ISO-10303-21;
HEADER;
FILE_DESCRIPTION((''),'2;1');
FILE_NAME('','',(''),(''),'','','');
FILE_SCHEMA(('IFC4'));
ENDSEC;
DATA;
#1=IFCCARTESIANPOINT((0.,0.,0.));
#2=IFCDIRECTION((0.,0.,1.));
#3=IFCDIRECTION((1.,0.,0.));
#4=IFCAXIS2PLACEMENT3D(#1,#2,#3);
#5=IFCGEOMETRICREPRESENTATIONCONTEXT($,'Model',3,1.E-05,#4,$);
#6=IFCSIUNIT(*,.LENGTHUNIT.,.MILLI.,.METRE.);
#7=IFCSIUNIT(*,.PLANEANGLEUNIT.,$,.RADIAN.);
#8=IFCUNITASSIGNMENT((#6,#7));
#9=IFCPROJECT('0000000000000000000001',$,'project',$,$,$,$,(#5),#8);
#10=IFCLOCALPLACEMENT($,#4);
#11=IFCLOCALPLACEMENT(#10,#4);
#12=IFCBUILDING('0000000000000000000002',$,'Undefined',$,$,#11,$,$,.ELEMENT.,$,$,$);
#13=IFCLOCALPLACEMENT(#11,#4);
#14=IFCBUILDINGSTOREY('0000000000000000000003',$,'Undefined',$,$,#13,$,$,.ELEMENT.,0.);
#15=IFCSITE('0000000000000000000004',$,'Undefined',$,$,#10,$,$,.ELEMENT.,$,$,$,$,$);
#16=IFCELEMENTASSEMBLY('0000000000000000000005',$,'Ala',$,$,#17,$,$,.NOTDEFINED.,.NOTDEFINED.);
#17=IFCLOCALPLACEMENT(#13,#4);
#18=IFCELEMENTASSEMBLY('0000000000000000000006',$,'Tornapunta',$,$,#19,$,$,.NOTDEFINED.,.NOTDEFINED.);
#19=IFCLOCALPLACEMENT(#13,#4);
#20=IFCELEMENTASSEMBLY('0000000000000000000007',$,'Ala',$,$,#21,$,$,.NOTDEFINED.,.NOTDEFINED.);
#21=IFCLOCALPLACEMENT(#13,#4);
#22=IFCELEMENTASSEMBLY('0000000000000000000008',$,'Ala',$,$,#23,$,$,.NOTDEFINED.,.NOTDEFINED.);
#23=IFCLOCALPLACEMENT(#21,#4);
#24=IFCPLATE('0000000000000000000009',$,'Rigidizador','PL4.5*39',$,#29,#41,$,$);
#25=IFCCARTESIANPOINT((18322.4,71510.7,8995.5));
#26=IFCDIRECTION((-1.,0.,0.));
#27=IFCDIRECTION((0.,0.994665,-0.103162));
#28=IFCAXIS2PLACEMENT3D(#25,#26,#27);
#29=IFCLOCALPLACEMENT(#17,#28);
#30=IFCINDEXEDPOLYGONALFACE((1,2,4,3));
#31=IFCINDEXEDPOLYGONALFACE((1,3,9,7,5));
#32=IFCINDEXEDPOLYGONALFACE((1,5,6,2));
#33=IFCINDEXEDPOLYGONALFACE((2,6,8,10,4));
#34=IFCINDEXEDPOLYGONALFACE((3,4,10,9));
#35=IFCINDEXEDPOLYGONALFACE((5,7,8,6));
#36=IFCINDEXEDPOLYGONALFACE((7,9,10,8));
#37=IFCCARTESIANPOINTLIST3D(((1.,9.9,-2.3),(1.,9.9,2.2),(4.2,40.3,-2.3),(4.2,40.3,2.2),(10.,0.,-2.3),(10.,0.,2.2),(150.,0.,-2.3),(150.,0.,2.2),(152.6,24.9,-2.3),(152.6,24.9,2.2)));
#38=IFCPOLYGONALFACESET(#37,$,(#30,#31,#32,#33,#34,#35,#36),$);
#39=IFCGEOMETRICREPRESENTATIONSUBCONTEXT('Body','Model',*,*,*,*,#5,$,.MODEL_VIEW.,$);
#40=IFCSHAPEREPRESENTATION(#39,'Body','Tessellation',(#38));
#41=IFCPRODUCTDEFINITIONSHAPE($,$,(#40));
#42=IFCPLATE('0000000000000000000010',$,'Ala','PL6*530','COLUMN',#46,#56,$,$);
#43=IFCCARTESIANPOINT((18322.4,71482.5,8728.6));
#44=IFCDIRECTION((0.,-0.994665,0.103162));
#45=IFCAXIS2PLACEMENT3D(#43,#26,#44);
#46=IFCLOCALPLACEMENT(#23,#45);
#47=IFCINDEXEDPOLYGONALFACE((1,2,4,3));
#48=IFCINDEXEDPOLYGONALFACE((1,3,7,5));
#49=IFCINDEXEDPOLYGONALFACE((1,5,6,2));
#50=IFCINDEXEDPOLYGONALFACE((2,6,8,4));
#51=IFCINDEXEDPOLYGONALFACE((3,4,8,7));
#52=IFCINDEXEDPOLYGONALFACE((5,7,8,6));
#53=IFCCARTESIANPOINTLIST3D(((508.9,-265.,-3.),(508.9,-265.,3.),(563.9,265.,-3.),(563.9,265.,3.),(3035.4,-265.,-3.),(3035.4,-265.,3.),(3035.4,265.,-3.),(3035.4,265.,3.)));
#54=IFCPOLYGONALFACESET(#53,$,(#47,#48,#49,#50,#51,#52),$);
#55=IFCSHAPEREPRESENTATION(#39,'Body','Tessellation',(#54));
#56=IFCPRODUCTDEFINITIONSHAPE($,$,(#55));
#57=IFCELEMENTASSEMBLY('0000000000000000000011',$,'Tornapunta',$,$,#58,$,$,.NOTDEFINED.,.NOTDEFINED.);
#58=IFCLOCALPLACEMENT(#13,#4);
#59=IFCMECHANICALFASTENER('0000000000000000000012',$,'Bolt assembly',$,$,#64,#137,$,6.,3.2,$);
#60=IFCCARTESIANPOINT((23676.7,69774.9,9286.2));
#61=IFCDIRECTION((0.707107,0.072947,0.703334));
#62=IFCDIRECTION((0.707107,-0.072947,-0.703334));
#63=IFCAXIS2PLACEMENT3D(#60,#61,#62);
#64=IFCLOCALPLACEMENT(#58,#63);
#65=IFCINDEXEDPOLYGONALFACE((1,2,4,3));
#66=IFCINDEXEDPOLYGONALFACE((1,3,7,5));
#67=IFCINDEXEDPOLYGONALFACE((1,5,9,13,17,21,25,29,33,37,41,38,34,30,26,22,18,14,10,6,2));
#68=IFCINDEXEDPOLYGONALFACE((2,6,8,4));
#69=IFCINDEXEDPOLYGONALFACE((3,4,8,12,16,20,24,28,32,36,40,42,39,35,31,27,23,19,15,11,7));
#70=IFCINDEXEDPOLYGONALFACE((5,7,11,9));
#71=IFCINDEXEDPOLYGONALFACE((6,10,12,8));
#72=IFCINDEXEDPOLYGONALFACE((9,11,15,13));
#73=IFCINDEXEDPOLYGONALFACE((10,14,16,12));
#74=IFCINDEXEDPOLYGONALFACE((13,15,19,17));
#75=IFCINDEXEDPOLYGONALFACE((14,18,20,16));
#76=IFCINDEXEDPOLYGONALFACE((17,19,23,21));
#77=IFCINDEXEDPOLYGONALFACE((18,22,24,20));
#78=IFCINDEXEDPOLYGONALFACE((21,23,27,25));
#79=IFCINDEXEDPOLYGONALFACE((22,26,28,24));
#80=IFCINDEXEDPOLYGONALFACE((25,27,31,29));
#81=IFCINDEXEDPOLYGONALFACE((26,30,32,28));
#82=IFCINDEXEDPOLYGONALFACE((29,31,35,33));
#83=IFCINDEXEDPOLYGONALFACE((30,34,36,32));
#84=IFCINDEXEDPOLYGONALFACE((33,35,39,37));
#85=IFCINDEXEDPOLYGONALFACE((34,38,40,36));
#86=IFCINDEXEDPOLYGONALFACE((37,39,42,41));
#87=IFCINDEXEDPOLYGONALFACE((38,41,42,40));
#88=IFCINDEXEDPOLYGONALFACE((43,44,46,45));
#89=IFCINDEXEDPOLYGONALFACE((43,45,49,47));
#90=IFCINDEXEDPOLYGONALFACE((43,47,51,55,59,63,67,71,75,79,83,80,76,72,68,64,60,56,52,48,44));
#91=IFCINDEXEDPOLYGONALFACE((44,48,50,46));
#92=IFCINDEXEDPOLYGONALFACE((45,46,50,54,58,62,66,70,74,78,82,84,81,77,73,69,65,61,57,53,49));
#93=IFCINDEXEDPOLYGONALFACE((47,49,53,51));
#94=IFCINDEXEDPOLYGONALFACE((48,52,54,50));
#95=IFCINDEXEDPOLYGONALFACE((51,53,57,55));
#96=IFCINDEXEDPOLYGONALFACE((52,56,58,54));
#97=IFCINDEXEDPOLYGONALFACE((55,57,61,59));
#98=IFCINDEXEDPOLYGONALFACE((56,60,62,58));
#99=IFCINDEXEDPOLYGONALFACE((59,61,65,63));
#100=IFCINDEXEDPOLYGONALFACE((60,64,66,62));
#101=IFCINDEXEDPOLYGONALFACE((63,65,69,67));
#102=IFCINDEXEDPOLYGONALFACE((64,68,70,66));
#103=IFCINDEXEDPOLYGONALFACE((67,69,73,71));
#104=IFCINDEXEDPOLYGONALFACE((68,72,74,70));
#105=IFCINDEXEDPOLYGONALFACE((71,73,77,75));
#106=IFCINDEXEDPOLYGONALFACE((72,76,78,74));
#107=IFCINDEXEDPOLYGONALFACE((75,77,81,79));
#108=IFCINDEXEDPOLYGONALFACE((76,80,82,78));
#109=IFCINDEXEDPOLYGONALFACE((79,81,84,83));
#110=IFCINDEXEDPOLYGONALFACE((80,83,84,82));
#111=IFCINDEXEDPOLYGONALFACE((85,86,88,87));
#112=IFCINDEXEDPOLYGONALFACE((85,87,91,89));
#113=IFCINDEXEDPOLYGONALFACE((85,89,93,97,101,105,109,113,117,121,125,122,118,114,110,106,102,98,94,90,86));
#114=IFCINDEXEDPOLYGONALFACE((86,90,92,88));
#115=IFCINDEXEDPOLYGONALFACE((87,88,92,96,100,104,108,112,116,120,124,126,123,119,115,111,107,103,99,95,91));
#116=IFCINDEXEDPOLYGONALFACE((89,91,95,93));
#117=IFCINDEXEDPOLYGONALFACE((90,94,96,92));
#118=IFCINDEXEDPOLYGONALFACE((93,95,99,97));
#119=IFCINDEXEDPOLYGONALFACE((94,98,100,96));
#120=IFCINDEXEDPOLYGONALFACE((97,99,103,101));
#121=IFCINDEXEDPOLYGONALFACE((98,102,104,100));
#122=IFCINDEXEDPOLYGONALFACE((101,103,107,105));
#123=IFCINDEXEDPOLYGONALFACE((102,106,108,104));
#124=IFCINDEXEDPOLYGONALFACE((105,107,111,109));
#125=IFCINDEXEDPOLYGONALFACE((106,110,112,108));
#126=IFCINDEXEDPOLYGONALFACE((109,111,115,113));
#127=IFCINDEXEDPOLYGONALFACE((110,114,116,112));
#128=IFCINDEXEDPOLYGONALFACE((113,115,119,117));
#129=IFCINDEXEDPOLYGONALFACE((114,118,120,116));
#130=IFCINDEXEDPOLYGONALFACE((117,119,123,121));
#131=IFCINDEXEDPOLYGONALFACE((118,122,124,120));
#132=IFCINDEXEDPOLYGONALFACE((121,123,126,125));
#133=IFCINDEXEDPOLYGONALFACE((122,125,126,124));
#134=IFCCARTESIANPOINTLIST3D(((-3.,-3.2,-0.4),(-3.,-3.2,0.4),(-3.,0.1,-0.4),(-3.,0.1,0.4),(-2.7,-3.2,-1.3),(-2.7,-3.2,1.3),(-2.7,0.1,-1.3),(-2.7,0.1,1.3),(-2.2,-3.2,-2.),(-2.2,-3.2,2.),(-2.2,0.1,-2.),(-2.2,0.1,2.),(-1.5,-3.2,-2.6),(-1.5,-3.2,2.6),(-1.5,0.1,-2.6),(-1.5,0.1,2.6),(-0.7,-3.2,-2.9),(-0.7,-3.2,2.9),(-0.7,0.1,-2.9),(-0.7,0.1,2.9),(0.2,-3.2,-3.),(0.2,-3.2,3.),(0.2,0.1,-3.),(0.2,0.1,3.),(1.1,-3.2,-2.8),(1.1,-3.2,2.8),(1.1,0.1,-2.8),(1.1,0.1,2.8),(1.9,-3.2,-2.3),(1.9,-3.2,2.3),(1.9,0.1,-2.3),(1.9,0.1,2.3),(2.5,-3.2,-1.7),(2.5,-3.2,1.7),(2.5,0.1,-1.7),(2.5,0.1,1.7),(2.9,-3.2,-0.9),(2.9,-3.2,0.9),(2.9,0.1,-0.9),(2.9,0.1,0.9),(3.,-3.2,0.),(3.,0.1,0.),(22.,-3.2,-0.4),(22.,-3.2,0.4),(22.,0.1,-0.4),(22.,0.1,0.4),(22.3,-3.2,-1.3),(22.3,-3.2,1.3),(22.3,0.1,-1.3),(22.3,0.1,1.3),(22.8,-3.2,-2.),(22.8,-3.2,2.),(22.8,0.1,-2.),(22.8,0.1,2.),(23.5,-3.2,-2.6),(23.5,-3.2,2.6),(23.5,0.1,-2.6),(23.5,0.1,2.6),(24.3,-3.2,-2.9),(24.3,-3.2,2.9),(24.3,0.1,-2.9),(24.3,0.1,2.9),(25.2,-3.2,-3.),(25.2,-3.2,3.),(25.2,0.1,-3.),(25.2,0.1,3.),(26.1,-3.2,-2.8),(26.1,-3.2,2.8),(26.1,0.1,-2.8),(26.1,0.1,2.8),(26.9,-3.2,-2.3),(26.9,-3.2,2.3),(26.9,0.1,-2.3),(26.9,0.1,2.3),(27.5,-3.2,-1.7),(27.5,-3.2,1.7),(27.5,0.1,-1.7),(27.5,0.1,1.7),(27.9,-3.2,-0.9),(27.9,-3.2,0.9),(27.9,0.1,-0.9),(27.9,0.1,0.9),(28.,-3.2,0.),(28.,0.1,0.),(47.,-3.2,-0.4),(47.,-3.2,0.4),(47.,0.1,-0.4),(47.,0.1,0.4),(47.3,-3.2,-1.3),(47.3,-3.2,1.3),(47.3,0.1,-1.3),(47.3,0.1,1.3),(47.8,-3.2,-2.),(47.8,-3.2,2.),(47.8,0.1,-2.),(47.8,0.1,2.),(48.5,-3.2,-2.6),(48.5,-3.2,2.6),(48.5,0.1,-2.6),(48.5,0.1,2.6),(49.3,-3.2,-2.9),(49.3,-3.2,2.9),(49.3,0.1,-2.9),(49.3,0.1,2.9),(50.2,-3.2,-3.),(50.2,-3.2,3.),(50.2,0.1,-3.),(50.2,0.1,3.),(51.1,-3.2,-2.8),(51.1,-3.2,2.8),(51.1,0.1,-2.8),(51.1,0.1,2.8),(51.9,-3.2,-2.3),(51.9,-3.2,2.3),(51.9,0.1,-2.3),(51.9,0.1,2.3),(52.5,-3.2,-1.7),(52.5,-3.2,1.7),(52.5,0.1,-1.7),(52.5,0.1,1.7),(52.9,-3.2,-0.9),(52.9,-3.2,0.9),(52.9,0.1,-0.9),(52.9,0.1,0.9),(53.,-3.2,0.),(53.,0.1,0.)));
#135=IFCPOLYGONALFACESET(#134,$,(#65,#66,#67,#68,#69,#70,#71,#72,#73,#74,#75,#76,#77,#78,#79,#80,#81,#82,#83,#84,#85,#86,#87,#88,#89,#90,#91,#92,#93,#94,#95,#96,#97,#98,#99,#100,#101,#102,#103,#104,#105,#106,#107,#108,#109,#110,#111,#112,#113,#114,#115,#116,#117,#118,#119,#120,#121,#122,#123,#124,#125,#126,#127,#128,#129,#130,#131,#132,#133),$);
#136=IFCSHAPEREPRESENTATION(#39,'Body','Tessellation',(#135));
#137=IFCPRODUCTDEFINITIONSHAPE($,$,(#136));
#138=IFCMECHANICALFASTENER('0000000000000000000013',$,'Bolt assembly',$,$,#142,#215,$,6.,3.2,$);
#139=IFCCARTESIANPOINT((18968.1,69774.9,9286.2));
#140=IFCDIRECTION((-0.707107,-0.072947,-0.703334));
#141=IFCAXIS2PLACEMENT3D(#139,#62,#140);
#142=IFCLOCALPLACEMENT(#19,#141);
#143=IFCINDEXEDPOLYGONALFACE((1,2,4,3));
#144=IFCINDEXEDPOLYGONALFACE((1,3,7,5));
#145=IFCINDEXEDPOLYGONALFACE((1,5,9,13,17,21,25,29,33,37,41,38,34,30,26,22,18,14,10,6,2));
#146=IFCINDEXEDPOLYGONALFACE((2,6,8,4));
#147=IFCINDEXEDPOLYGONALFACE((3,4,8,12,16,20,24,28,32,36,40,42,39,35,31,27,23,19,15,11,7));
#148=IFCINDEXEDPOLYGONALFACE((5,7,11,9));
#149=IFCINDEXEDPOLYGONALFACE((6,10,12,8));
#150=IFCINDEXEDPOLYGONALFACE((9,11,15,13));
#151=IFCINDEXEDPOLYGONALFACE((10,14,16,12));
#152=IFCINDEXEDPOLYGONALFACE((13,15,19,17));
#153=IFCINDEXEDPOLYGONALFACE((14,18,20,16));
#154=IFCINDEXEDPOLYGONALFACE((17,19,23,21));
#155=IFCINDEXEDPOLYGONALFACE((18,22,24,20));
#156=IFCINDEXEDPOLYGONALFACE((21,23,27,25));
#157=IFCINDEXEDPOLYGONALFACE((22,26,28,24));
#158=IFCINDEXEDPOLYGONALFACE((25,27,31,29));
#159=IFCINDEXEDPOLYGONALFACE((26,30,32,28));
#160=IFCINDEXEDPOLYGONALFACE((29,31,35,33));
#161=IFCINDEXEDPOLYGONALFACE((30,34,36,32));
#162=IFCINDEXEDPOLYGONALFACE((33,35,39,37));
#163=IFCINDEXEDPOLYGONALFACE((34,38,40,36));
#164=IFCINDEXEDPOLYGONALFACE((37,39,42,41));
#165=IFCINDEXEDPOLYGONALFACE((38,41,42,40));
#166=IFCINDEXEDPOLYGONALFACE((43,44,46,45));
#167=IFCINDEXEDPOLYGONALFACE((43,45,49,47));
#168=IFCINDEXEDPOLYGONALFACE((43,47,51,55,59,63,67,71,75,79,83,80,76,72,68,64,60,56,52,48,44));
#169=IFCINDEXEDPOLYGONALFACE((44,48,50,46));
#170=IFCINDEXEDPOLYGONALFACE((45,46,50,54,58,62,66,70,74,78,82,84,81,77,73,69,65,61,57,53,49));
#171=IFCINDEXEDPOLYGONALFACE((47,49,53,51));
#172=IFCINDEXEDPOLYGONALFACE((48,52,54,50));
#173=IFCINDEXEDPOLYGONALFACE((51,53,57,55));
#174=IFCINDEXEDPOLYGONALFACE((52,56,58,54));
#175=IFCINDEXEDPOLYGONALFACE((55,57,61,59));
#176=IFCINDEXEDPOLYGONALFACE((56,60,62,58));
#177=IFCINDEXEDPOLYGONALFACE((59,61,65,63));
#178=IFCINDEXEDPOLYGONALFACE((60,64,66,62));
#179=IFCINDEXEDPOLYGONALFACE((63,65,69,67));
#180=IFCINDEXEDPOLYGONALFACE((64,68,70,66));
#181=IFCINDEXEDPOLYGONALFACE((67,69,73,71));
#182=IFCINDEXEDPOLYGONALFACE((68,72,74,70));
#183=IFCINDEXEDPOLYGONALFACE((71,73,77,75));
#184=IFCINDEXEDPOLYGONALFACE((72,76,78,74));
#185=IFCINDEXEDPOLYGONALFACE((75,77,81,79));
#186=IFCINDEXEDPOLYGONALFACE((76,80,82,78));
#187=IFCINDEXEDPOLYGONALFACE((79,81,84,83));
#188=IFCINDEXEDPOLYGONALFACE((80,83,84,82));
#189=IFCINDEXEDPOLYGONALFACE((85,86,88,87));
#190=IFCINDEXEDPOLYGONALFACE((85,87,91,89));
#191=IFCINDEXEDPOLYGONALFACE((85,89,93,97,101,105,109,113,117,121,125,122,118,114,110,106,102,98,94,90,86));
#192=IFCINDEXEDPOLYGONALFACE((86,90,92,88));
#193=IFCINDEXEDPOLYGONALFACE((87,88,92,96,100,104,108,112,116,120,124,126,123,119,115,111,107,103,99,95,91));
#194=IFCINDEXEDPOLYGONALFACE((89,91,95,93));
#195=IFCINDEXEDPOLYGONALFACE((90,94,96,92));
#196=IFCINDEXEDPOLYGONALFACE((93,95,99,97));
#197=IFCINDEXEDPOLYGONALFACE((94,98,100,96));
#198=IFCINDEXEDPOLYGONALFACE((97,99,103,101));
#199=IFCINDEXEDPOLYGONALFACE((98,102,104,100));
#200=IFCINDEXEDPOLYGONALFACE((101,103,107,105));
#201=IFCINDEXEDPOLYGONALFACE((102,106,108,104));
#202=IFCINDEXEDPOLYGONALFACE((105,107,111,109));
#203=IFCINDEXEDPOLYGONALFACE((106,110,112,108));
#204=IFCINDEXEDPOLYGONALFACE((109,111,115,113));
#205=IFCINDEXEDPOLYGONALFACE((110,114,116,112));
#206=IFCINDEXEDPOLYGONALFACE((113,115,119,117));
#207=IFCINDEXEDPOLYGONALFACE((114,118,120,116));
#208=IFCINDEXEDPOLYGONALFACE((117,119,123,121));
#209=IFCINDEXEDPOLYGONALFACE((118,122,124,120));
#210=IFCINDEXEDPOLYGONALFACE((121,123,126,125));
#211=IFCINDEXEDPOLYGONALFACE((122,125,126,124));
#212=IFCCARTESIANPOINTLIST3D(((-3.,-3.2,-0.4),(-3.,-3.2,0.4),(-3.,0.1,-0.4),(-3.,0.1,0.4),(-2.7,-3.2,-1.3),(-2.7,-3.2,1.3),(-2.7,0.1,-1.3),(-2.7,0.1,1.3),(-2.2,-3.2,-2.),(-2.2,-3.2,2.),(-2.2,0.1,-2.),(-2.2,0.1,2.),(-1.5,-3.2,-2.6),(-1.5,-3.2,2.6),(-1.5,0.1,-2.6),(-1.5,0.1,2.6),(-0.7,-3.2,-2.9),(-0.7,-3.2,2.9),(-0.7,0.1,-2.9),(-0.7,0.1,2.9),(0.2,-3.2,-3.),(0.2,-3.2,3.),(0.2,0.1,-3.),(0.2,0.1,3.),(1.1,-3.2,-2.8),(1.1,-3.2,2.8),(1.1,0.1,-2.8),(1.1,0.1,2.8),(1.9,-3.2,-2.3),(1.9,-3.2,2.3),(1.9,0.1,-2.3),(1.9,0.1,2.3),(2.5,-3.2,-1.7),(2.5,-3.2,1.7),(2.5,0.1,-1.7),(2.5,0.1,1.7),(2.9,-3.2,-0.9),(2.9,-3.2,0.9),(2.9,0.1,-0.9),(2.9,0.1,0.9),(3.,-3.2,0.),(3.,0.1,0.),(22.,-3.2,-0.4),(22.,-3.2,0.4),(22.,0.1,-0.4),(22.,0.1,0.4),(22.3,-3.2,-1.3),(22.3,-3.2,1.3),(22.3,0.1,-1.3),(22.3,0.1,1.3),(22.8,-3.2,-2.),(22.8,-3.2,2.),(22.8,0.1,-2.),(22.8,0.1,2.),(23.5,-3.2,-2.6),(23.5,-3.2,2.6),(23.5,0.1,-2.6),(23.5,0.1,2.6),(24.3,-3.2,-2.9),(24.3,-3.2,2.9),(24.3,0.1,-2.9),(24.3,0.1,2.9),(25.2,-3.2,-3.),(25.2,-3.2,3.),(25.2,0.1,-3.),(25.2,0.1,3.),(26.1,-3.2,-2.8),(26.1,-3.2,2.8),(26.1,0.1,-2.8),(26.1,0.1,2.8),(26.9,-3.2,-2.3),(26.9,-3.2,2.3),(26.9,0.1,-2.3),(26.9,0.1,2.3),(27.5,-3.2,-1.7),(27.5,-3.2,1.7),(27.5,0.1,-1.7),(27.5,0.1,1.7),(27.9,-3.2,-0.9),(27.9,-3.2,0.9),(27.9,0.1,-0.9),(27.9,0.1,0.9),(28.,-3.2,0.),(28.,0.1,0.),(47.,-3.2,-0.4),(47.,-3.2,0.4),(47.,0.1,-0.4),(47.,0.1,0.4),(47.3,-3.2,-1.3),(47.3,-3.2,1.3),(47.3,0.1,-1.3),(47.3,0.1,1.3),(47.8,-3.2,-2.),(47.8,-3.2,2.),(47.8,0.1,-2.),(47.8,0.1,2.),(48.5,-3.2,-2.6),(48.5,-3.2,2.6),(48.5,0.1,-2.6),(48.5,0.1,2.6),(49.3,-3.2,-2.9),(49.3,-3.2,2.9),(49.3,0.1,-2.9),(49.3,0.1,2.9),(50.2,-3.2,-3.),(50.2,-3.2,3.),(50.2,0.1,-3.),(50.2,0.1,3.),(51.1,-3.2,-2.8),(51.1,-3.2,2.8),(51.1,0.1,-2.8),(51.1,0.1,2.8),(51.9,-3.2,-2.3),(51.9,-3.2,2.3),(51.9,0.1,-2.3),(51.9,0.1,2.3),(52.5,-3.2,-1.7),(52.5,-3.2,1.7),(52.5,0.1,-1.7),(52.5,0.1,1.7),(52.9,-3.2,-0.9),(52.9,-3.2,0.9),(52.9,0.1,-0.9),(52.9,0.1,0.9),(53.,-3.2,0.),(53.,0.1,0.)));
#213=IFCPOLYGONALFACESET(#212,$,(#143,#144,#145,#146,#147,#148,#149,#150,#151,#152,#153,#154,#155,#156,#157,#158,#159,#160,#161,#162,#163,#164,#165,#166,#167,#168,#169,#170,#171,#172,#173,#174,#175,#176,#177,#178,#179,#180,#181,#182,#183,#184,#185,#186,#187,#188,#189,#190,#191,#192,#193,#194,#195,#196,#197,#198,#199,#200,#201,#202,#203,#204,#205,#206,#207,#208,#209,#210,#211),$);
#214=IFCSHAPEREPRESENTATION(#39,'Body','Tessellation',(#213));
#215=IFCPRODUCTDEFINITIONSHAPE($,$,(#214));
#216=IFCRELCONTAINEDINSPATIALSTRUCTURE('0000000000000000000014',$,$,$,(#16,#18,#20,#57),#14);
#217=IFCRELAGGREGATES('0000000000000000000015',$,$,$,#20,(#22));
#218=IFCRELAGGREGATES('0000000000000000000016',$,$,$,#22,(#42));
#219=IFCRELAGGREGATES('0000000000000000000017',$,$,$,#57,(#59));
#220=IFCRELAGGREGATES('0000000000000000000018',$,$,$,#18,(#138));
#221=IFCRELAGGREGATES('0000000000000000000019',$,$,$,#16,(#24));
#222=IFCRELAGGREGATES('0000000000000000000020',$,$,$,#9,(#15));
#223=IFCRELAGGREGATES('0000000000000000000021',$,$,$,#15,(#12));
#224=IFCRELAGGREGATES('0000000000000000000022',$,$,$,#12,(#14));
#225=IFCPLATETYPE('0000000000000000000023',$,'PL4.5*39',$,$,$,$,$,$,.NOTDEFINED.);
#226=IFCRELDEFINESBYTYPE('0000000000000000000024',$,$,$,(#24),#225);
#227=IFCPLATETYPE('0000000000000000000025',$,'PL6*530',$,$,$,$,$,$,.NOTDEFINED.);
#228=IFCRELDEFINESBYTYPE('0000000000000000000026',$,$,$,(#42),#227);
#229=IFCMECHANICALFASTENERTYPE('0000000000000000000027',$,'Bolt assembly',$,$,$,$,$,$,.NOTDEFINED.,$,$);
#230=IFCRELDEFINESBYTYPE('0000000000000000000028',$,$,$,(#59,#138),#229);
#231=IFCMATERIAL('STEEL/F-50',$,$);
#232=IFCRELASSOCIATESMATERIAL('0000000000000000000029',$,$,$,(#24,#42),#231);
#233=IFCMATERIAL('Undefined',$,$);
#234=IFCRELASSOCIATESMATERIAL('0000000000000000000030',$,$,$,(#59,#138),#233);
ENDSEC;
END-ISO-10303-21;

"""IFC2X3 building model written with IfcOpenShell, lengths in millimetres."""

from ifc_helpers import new_model, si_unit, frame, origin_with_axes, origin_2d_with_axis, place, context, subcontext, project, spatial, polyline, circle, outline, extrude, clip, halfspace, source, transform, mapped, material, type_object, element, aggregate, save


model = new_model("IFC2X3")

# Units and contexts
model_context = context("Model", 3, precision=1e-05, world=origin_with_axes())
body_context = subcontext(model_context, "Body", "Model", "MODEL_VIEW")
ifc_project = project(units=[si_unit("LENGTHUNIT", "METRE", prefix="MILLI"), si_unit("PLANEANGLEUNIT", "RADIAN")], contexts=[model_context])

# Site, building, storey
site_placement = place(None, origin_with_axes())
site = spatial("IfcSite", under=ifc_project, at=site_placement, Name="Undefined", CompositionType="ELEMENT")
building_placement = place(site_placement, origin_with_axes())
building = spatial("IfcBuilding", under=site, at=building_placement, Name="Undefined", CompositionType="ELEMENT")
storey_placement = place(building_placement, origin_with_axes())
storey = spatial("IfcBuildingStorey", under=building, at=storey_placement, Name="Undefined", CompositionType="ELEMENT", Elevation=0.0)

# Element assembly
assembly_1_placement = place(storey_placement, origin_with_axes())
assembly_1 = element("IfcElementAssembly", 1, at=assembly_1_placement, inside=storey, Name="Ala", AssemblyPlace="NOTDEFINED", PredefinedType="NOTDEFINED")
ifc_material_1 = material(Name="STEEL/F-50")

# Element assembly
assembly_2_placement = place(storey_placement, origin_with_axes())
assembly_2 = element("IfcElementAssembly", 2, at=assembly_2_placement, inside=storey, Name="Tornapunta", AssemblyPlace="NOTDEFINED", PredefinedType="NOTDEFINED")

# Element assemblies
assembly_3_placement = place(storey_placement, origin_with_axes())
assembly_3 = element("IfcElementAssembly", 3, at=assembly_3_placement, inside=storey, Name="Ala", AssemblyPlace="NOTDEFINED", PredefinedType="NOTDEFINED")
assembly_4_placement = place(assembly_3_placement, origin_with_axes())
assembly_4 = element("IfcElementAssembly", 4, at=assembly_4_placement, Name="Ala", AssemblyPlace="NOTDEFINED", PredefinedType="NOTDEFINED")
aggregate(assembly_3, [assembly_4])

# Plates
plate_type_1 = type_object("IfcPlateType", Name="PL4.5*39", PredefinedType="NOTDEFINED")
plate_1_placement = place(assembly_1_placement, frame((18322.4, 71510.7, 8995.5), z_axis=(-1.0, 0.0, 0.0), x_axis=(0.0, 0.994665, -0.103162)))
plate_1 = element("IfcPlate", 5, at=plate_1_placement, type_object=plate_type_1, material=ifc_material_1, Name="Rigidizador", Description="PL4.5*39", context=body_context, shape_type="SweptSolid", body=[
    extrude(outline(polyline([(1.0, 9.9), (10.0, 0.0), (150.0, 0.0), (152.6, 24.9), (4.2, 40.3), (1.0, 9.9)])), frame((0.0, 0.0, -2.2), z_axis=(0.0, 0.0, 1.0), x_axis=(1.0, 0.0, 0.0)), (0.0, 0.0, 1.0), 4.5),
])
plate_type_2 = type_object("IfcPlateType", Name="PL6*530", PredefinedType="NOTDEFINED")
plate_2_placement = place(assembly_4_placement, frame((18322.4, 71482.5, 8728.6), z_axis=(-1.0, 0.0, 0.0), x_axis=(0.0, -0.994665, 0.103162)))
plate_2 = element("IfcPlate", 6, at=plate_2_placement, type_object=plate_type_2, material=ifc_material_1, Name="Ala", Description="PL6*530", ObjectType="COLUMN", context=body_context, shape_type="Clipping", body=[
    clip(clip(extrude(outline(polyline([(508.9, -265.0), (508.9, 265.0), (3035.4, 265.0), (3035.4, -265.0), (508.9, -265.0)])), frame((0.0, 0.0, -3.0), z_axis=(0.0, 0.0, 1.0), x_axis=(1.0, 0.0, 0.0)), (0.0, 0.0, 1.0), 6.0), halfspace(frame((3035.4, 0.0, 0.0), z_axis=(-1.0, 0.0, 0.0), x_axis=(0.0, 0.0, -1.0)), True)), halfspace(frame((536.4, 0.0, 0.0), z_axis=(-0.994665, 0.103162, 0.0), x_axis=(0.0, 0.0, -1.0)), False)),
])
aggregate(assembly_4, [plate_2])

# Element assembly, mechanical fastener
assembly_5_placement = place(storey_placement, origin_with_axes())
assembly_5 = element("IfcElementAssembly", 7, at=assembly_5_placement, inside=storey, Name="Tornapunta", AssemblyPlace="NOTDEFINED", PredefinedType="NOTDEFINED")
ifc_material_2 = material(Name="Undefined")
mechanical_fastener_type = type_object("IfcMechanicalFastenerType", Name="Bolt assembly")
shared_shape_1 = source(origin_with_axes(), body_context, "Body", "SweptSolid", [
    extrude(circle(Radius=3.0, at=origin_2d_with_axis()), frame((0.0, -3.2, 0.0), z_axis=(0.0, 1.0, 0.0), x_axis=(1.0, 0.0, 0.0)), (0.0, 0.0, 1.0), 3.3),
])
mechanical_fastener_1_placement = place(assembly_5_placement, frame((23676.7, 69774.9, 9286.2), z_axis=(0.707107, 0.072947, 0.703334), x_axis=(0.707107, -0.072947, -0.703334)))
mechanical_fastener_1 = element("IfcMechanicalFastener", 8, at=mechanical_fastener_1_placement, type_object=mechanical_fastener_type, material=ifc_material_2, Name="Bolt assembly", NominalDiameter=6.0, NominalLength=3.2, context=body_context, shape_type="MappedRepresentation", body=[
    mapped(shared_shape_1, transform((0.0, 0.0, 0.0))),
    mapped(shared_shape_1, transform((25.0, 0.0, 0.0))),
    mapped(shared_shape_1, transform((50.0, 0.0, 0.0))),
])

# Mechanical fastener
mechanical_fastener_2_placement = place(assembly_2_placement, frame((18968.1, 69774.9, 9286.2), z_axis=(0.707107, -0.072947, -0.703334), x_axis=(-0.707107, -0.072947, -0.703334)))
mechanical_fastener_2 = element("IfcMechanicalFastener", 9, at=mechanical_fastener_2_placement, type_object=mechanical_fastener_type, material=ifc_material_2, Name="Bolt assembly", NominalDiameter=6.0, NominalLength=3.2, context=body_context, shape_type="MappedRepresentation", body=[
    mapped(shared_shape_1, transform((0.0, 0.0, 0.0))),
    mapped(shared_shape_1, transform((25.0, 0.0, 0.0))),
    mapped(shared_shape_1, transform((50.0, 0.0, 0.0))),
])
aggregate(assembly_5, [mechanical_fastener_1])
aggregate(assembly_2, [mechanical_fastener_2])

aggregate(assembly_1, [plate_1])

save(model, "model.ifc")
